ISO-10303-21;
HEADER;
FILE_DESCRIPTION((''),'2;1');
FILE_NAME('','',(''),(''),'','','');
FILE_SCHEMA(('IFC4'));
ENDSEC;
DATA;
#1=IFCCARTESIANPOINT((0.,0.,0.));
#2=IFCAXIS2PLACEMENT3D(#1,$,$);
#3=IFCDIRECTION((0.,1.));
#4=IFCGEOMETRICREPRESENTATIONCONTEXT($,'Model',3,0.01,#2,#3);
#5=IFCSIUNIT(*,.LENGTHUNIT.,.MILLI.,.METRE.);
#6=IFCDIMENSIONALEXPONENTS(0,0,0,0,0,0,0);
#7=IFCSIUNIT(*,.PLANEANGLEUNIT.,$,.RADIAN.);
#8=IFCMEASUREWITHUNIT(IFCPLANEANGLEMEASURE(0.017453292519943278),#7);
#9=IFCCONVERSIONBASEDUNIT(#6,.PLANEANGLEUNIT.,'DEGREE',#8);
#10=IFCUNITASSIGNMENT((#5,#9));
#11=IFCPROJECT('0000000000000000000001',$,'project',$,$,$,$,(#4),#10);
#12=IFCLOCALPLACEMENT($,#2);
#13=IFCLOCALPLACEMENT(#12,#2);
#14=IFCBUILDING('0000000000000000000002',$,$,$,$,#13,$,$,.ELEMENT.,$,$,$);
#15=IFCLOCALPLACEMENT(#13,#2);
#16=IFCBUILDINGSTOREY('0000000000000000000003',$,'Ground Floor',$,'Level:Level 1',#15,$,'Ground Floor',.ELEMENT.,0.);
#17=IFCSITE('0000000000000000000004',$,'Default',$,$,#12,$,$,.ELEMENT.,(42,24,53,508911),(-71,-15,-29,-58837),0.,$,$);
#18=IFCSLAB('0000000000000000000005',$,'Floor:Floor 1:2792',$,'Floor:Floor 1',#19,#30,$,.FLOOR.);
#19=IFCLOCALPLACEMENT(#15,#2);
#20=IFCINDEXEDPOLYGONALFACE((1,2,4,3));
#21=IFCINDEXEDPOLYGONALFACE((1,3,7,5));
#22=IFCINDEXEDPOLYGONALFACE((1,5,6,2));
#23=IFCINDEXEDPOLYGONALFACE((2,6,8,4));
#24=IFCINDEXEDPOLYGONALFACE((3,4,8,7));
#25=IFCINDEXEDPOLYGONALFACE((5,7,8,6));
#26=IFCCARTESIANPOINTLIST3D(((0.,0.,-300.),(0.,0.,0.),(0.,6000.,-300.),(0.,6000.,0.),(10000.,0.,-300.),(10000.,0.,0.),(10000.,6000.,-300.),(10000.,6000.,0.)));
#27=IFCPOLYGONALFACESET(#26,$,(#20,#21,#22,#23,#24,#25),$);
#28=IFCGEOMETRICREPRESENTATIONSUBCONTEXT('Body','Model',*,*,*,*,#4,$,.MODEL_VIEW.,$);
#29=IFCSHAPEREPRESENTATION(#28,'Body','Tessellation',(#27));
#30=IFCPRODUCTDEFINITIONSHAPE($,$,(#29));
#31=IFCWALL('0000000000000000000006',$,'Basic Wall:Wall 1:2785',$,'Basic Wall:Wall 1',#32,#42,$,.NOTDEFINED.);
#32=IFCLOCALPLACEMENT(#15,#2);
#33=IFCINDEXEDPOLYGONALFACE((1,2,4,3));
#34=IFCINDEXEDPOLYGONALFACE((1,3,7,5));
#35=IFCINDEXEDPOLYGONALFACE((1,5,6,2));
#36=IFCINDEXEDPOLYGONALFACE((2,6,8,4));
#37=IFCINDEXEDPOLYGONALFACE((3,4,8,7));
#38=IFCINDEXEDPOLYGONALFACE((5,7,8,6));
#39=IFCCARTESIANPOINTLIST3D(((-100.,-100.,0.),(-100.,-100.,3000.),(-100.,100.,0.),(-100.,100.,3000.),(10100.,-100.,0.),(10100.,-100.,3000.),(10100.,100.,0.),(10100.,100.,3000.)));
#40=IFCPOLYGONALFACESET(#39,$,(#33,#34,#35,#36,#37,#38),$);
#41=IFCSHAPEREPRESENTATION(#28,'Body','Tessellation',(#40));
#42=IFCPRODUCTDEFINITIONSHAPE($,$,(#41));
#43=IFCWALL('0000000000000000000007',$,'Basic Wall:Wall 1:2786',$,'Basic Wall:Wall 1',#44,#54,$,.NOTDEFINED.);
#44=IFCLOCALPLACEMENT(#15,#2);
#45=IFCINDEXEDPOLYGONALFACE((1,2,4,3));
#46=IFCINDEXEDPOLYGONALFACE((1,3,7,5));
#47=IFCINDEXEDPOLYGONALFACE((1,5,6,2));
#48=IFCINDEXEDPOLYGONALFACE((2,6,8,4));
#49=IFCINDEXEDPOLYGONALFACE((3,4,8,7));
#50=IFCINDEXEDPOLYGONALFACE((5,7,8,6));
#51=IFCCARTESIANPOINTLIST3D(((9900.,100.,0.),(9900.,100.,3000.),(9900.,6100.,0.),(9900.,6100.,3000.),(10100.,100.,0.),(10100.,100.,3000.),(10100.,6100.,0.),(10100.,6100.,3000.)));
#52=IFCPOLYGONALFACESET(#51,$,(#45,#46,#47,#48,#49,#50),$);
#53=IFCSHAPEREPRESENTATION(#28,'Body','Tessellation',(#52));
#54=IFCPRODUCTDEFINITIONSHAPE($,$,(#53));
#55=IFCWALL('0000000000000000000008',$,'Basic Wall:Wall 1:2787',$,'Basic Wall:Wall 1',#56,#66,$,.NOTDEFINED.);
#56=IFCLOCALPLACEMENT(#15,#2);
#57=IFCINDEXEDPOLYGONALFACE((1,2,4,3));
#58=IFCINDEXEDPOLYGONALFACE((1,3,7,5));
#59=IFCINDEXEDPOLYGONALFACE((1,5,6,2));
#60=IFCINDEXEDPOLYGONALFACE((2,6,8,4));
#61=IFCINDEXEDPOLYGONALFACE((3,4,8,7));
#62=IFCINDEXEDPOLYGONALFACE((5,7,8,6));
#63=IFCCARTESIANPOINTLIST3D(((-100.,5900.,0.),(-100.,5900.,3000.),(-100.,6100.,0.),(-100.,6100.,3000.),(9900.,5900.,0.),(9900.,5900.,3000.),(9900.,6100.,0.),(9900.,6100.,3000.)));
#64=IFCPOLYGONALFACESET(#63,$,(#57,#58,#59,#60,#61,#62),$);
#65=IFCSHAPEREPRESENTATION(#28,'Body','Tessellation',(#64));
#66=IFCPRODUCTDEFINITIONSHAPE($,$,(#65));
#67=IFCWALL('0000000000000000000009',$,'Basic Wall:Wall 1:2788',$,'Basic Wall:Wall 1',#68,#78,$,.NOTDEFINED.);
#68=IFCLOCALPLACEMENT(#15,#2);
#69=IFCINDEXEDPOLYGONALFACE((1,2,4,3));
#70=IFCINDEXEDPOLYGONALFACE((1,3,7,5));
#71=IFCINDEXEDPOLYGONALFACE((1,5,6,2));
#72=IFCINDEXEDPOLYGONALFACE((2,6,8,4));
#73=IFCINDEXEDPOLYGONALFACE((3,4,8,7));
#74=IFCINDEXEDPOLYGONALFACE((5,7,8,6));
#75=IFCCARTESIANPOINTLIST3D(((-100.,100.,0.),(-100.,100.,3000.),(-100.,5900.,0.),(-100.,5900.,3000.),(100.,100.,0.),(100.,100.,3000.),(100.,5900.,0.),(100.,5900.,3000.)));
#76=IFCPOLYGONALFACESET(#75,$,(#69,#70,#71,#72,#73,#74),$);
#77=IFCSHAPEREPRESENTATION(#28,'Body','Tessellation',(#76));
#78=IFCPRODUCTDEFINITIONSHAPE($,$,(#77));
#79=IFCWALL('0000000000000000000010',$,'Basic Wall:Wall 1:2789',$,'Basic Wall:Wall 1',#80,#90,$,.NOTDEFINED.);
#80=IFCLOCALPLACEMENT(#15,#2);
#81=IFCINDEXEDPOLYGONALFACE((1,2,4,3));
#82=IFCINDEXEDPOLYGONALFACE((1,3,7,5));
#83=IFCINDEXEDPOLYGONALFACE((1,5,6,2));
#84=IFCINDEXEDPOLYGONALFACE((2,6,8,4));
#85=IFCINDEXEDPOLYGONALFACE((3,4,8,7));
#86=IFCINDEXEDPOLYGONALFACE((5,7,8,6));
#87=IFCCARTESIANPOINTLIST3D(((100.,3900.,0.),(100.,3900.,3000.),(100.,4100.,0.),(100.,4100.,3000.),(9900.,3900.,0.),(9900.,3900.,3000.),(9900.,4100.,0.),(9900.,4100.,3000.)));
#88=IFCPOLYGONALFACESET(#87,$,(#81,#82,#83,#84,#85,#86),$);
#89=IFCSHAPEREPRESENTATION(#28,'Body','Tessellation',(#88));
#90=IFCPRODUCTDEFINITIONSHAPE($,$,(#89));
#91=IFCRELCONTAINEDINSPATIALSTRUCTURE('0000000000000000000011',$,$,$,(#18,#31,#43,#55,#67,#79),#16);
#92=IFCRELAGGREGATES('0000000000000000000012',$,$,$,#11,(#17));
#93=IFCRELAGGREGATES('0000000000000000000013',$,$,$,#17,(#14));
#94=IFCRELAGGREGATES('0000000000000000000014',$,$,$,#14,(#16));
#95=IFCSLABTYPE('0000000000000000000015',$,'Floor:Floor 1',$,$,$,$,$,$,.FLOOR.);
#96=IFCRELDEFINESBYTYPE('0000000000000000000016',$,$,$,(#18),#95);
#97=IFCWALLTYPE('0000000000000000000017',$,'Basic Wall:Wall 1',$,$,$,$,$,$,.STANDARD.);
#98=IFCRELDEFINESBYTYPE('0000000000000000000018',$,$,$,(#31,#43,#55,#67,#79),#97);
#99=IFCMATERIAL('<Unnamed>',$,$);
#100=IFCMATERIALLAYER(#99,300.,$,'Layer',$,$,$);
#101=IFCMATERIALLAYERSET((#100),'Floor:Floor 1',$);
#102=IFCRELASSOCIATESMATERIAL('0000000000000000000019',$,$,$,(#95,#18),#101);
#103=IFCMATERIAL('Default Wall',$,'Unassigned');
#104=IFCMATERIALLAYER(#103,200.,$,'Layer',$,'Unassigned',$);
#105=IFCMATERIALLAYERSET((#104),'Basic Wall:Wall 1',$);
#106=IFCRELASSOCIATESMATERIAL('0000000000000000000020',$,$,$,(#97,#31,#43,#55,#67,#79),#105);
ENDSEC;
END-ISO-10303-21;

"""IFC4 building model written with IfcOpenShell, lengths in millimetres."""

from ifc_helpers import new_model, entity, si_unit, converted_unit, direction, frame, frame_2d, origin, origin_2d_with_axis, place, context, subcontext, project, spatial, rectangle, extrude, material, layer, layer_set, layer_usage, type_object, element, save


model = new_model("IFC4")

# Units and contexts
model_context = context("Model", 3, precision=0.01, world=origin(), true_north=direction((0.0, 1.0)))
body_context = subcontext(model_context, "Body", "Model", "MODEL_VIEW")
ifc_project = project(units=[si_unit("LENGTHUNIT", "METRE", prefix="MILLI"), converted_unit("PLANEANGLEUNIT", "DEGREE", entity("IfcPlaneAngleMeasure", 0.017453292519943278), si_unit("PLANEANGLEUNIT", "RADIAN"), dimensions=[0, 0, 0, 0, 0, 0, 0])], contexts=[model_context])

# Site, building, storey
site_placement = place(None, origin())
site = spatial("IfcSite", under=ifc_project, at=site_placement, Name="Default", CompositionType="ELEMENT", RefLatitude=(42, 24, 53, 508911), RefLongitude=(-71, -15, -29, -58837), RefElevation=0.0)
building_placement = place(site_placement, origin())
building = spatial("IfcBuilding", under=site, at=building_placement, CompositionType="ELEMENT")
storey_placement = place(building_placement, origin())
storey = spatial("IfcBuildingStorey", under=building, at=storey_placement, Name="Ground Floor", ObjectType="Level:Level 1", LongName="Ground Floor", CompositionType="ELEMENT", Elevation=0.0)

# Slab
ifc_material_1 = material(Name="<Unnamed>")
ifc_layer_1 = layer(ifc_material_1, 300.0, Name="Layer")
ifc_layer_set_1 = layer_set([ifc_layer_1], Name="Floor:Floor 1")
ifc_layer_usage_1 = layer_usage(ifc_layer_set_1, "AXIS3", "POSITIVE", 0.0)
slab_type = type_object("IfcSlabType", Name="Floor:Floor 1", PredefinedType="FLOOR", material=ifc_layer_set_1)
slab_placement = place(storey_placement, origin())
element("IfcSlab", 1, at=slab_placement, inside=storey, type_object=slab_type, material=ifc_layer_usage_1, Name="Floor:Floor 1:2792", ObjectType="Floor:Floor 1", PredefinedType="FLOOR", context=body_context, shape_type="SweptSolid", body=[
    extrude(rectangle(XDim=6000.0, YDim=10000.0, at=origin_2d_with_axis()), frame((5000.0, 3000.0, 0.0), z_axis=(0.0, 0.0, -1.0), x_axis=(0.0, 1.0, 0.0)), (0.0, 0.0, 1.0), 300.0),
])

# Walls
ifc_material_2 = material(Name="Default Wall", Category="Unassigned")
ifc_layer_2 = layer(ifc_material_2, 200.0, Name="Layer", Category="Unassigned")
ifc_layer_set_2 = layer_set([ifc_layer_2], Name="Basic Wall:Wall 1")
ifc_layer_usage_2 = layer_usage(ifc_layer_set_2, "AXIS2", "NEGATIVE", 100.0)
wall_type = type_object("IfcWallType", Name="Basic Wall:Wall 1", PredefinedType="STANDARD", material=ifc_layer_set_2)
wall_1_placement = place(storey_placement, frame((-100.0, 0.0, 0.0)))
element("IfcWall", 2, at=wall_1_placement, inside=storey, type_object=wall_type, material=ifc_layer_usage_2, Name="Basic Wall:Wall 1:2785", ObjectType="Basic Wall:Wall 1", PredefinedType="NOTDEFINED", context=body_context, shape_type="SweptSolid", body=[
    extrude(rectangle(XDim=10200.0, YDim=200.0, at=frame_2d((5100.0, 0.0), x_axis=(-1.0, 0.0))), origin(), (0.0, 0.0, 1.0), 3000.0),
])
ifc_layer_usage_3 = layer_usage(ifc_layer_set_2, "AXIS2", "NEGATIVE", 100.0)
wall_2_placement = place(storey_placement, frame((10000.0, 100.0, 0.0), z_axis=(0.0, 0.0, 1.0), x_axis=(0.0, 1.0, 0.0)))
element("IfcWall", 3, at=wall_2_placement, inside=storey, type_object=wall_type, material=ifc_layer_usage_3, Name="Basic Wall:Wall 1:2786", ObjectType="Basic Wall:Wall 1", PredefinedType="NOTDEFINED", context=body_context, shape_type="SweptSolid", body=[
    extrude(rectangle(XDim=6000.0, YDim=200.0, at=frame_2d((3000.0, 0.0), x_axis=(-1.0, 0.0))), origin(), (0.0, 0.0, 1.0), 3000.0),
])
ifc_layer_usage_4 = layer_usage(ifc_layer_set_2, "AXIS2", "NEGATIVE", 100.0)
wall_3_placement = place(storey_placement, frame((9900.0, 6000.0, 0.0), z_axis=(0.0, 0.0, 1.0), x_axis=(-1.0, 0.0, 0.0)))
element("IfcWall", 4, at=wall_3_placement, inside=storey, type_object=wall_type, material=ifc_layer_usage_4, Name="Basic Wall:Wall 1:2787", ObjectType="Basic Wall:Wall 1", PredefinedType="NOTDEFINED", context=body_context, shape_type="SweptSolid", body=[
    extrude(rectangle(XDim=10000.0, YDim=200.0, at=frame_2d((5000.0, 0.0), x_axis=(-1.0, 0.0))), origin(), (0.0, 0.0, 1.0), 3000.0),
])
ifc_layer_usage_5 = layer_usage(ifc_layer_set_2, "AXIS2", "NEGATIVE", 100.0)
wall_4_placement = place(storey_placement, frame((0.0, 5900.0, 0.0), z_axis=(0.0, 0.0, 1.0), x_axis=(0.0, -1.0, 0.0)))
element("IfcWall", 5, at=wall_4_placement, inside=storey, type_object=wall_type, material=ifc_layer_usage_5, Name="Basic Wall:Wall 1:2788", ObjectType="Basic Wall:Wall 1", PredefinedType="NOTDEFINED", context=body_context, shape_type="SweptSolid", body=[
    extrude(rectangle(XDim=5800.0, YDim=200.0, at=frame_2d((2900.0, 0.0), x_axis=(-1.0, 0.0))), origin(), (0.0, 0.0, 1.0), 3000.0),
])
ifc_layer_usage_6 = layer_usage(ifc_layer_set_2, "AXIS2", "NEGATIVE", 100.0)
wall_5_placement = place(storey_placement, frame((100.0, 4000.0, 0.0)))
element("IfcWall", 6, at=wall_5_placement, inside=storey, type_object=wall_type, material=ifc_layer_usage_6, Name="Basic Wall:Wall 1:2789", ObjectType="Basic Wall:Wall 1", PredefinedType="NOTDEFINED", context=body_context, shape_type="SweptSolid", body=[
    extrude(rectangle(XDim=9800.0, YDim=200.0, at=frame_2d((4900.0, 0.0), x_axis=(-1.0, 0.0))), origin(), (0.0, 0.0, 1.0), 3000.0),
])

save(model, "model.ifc")
